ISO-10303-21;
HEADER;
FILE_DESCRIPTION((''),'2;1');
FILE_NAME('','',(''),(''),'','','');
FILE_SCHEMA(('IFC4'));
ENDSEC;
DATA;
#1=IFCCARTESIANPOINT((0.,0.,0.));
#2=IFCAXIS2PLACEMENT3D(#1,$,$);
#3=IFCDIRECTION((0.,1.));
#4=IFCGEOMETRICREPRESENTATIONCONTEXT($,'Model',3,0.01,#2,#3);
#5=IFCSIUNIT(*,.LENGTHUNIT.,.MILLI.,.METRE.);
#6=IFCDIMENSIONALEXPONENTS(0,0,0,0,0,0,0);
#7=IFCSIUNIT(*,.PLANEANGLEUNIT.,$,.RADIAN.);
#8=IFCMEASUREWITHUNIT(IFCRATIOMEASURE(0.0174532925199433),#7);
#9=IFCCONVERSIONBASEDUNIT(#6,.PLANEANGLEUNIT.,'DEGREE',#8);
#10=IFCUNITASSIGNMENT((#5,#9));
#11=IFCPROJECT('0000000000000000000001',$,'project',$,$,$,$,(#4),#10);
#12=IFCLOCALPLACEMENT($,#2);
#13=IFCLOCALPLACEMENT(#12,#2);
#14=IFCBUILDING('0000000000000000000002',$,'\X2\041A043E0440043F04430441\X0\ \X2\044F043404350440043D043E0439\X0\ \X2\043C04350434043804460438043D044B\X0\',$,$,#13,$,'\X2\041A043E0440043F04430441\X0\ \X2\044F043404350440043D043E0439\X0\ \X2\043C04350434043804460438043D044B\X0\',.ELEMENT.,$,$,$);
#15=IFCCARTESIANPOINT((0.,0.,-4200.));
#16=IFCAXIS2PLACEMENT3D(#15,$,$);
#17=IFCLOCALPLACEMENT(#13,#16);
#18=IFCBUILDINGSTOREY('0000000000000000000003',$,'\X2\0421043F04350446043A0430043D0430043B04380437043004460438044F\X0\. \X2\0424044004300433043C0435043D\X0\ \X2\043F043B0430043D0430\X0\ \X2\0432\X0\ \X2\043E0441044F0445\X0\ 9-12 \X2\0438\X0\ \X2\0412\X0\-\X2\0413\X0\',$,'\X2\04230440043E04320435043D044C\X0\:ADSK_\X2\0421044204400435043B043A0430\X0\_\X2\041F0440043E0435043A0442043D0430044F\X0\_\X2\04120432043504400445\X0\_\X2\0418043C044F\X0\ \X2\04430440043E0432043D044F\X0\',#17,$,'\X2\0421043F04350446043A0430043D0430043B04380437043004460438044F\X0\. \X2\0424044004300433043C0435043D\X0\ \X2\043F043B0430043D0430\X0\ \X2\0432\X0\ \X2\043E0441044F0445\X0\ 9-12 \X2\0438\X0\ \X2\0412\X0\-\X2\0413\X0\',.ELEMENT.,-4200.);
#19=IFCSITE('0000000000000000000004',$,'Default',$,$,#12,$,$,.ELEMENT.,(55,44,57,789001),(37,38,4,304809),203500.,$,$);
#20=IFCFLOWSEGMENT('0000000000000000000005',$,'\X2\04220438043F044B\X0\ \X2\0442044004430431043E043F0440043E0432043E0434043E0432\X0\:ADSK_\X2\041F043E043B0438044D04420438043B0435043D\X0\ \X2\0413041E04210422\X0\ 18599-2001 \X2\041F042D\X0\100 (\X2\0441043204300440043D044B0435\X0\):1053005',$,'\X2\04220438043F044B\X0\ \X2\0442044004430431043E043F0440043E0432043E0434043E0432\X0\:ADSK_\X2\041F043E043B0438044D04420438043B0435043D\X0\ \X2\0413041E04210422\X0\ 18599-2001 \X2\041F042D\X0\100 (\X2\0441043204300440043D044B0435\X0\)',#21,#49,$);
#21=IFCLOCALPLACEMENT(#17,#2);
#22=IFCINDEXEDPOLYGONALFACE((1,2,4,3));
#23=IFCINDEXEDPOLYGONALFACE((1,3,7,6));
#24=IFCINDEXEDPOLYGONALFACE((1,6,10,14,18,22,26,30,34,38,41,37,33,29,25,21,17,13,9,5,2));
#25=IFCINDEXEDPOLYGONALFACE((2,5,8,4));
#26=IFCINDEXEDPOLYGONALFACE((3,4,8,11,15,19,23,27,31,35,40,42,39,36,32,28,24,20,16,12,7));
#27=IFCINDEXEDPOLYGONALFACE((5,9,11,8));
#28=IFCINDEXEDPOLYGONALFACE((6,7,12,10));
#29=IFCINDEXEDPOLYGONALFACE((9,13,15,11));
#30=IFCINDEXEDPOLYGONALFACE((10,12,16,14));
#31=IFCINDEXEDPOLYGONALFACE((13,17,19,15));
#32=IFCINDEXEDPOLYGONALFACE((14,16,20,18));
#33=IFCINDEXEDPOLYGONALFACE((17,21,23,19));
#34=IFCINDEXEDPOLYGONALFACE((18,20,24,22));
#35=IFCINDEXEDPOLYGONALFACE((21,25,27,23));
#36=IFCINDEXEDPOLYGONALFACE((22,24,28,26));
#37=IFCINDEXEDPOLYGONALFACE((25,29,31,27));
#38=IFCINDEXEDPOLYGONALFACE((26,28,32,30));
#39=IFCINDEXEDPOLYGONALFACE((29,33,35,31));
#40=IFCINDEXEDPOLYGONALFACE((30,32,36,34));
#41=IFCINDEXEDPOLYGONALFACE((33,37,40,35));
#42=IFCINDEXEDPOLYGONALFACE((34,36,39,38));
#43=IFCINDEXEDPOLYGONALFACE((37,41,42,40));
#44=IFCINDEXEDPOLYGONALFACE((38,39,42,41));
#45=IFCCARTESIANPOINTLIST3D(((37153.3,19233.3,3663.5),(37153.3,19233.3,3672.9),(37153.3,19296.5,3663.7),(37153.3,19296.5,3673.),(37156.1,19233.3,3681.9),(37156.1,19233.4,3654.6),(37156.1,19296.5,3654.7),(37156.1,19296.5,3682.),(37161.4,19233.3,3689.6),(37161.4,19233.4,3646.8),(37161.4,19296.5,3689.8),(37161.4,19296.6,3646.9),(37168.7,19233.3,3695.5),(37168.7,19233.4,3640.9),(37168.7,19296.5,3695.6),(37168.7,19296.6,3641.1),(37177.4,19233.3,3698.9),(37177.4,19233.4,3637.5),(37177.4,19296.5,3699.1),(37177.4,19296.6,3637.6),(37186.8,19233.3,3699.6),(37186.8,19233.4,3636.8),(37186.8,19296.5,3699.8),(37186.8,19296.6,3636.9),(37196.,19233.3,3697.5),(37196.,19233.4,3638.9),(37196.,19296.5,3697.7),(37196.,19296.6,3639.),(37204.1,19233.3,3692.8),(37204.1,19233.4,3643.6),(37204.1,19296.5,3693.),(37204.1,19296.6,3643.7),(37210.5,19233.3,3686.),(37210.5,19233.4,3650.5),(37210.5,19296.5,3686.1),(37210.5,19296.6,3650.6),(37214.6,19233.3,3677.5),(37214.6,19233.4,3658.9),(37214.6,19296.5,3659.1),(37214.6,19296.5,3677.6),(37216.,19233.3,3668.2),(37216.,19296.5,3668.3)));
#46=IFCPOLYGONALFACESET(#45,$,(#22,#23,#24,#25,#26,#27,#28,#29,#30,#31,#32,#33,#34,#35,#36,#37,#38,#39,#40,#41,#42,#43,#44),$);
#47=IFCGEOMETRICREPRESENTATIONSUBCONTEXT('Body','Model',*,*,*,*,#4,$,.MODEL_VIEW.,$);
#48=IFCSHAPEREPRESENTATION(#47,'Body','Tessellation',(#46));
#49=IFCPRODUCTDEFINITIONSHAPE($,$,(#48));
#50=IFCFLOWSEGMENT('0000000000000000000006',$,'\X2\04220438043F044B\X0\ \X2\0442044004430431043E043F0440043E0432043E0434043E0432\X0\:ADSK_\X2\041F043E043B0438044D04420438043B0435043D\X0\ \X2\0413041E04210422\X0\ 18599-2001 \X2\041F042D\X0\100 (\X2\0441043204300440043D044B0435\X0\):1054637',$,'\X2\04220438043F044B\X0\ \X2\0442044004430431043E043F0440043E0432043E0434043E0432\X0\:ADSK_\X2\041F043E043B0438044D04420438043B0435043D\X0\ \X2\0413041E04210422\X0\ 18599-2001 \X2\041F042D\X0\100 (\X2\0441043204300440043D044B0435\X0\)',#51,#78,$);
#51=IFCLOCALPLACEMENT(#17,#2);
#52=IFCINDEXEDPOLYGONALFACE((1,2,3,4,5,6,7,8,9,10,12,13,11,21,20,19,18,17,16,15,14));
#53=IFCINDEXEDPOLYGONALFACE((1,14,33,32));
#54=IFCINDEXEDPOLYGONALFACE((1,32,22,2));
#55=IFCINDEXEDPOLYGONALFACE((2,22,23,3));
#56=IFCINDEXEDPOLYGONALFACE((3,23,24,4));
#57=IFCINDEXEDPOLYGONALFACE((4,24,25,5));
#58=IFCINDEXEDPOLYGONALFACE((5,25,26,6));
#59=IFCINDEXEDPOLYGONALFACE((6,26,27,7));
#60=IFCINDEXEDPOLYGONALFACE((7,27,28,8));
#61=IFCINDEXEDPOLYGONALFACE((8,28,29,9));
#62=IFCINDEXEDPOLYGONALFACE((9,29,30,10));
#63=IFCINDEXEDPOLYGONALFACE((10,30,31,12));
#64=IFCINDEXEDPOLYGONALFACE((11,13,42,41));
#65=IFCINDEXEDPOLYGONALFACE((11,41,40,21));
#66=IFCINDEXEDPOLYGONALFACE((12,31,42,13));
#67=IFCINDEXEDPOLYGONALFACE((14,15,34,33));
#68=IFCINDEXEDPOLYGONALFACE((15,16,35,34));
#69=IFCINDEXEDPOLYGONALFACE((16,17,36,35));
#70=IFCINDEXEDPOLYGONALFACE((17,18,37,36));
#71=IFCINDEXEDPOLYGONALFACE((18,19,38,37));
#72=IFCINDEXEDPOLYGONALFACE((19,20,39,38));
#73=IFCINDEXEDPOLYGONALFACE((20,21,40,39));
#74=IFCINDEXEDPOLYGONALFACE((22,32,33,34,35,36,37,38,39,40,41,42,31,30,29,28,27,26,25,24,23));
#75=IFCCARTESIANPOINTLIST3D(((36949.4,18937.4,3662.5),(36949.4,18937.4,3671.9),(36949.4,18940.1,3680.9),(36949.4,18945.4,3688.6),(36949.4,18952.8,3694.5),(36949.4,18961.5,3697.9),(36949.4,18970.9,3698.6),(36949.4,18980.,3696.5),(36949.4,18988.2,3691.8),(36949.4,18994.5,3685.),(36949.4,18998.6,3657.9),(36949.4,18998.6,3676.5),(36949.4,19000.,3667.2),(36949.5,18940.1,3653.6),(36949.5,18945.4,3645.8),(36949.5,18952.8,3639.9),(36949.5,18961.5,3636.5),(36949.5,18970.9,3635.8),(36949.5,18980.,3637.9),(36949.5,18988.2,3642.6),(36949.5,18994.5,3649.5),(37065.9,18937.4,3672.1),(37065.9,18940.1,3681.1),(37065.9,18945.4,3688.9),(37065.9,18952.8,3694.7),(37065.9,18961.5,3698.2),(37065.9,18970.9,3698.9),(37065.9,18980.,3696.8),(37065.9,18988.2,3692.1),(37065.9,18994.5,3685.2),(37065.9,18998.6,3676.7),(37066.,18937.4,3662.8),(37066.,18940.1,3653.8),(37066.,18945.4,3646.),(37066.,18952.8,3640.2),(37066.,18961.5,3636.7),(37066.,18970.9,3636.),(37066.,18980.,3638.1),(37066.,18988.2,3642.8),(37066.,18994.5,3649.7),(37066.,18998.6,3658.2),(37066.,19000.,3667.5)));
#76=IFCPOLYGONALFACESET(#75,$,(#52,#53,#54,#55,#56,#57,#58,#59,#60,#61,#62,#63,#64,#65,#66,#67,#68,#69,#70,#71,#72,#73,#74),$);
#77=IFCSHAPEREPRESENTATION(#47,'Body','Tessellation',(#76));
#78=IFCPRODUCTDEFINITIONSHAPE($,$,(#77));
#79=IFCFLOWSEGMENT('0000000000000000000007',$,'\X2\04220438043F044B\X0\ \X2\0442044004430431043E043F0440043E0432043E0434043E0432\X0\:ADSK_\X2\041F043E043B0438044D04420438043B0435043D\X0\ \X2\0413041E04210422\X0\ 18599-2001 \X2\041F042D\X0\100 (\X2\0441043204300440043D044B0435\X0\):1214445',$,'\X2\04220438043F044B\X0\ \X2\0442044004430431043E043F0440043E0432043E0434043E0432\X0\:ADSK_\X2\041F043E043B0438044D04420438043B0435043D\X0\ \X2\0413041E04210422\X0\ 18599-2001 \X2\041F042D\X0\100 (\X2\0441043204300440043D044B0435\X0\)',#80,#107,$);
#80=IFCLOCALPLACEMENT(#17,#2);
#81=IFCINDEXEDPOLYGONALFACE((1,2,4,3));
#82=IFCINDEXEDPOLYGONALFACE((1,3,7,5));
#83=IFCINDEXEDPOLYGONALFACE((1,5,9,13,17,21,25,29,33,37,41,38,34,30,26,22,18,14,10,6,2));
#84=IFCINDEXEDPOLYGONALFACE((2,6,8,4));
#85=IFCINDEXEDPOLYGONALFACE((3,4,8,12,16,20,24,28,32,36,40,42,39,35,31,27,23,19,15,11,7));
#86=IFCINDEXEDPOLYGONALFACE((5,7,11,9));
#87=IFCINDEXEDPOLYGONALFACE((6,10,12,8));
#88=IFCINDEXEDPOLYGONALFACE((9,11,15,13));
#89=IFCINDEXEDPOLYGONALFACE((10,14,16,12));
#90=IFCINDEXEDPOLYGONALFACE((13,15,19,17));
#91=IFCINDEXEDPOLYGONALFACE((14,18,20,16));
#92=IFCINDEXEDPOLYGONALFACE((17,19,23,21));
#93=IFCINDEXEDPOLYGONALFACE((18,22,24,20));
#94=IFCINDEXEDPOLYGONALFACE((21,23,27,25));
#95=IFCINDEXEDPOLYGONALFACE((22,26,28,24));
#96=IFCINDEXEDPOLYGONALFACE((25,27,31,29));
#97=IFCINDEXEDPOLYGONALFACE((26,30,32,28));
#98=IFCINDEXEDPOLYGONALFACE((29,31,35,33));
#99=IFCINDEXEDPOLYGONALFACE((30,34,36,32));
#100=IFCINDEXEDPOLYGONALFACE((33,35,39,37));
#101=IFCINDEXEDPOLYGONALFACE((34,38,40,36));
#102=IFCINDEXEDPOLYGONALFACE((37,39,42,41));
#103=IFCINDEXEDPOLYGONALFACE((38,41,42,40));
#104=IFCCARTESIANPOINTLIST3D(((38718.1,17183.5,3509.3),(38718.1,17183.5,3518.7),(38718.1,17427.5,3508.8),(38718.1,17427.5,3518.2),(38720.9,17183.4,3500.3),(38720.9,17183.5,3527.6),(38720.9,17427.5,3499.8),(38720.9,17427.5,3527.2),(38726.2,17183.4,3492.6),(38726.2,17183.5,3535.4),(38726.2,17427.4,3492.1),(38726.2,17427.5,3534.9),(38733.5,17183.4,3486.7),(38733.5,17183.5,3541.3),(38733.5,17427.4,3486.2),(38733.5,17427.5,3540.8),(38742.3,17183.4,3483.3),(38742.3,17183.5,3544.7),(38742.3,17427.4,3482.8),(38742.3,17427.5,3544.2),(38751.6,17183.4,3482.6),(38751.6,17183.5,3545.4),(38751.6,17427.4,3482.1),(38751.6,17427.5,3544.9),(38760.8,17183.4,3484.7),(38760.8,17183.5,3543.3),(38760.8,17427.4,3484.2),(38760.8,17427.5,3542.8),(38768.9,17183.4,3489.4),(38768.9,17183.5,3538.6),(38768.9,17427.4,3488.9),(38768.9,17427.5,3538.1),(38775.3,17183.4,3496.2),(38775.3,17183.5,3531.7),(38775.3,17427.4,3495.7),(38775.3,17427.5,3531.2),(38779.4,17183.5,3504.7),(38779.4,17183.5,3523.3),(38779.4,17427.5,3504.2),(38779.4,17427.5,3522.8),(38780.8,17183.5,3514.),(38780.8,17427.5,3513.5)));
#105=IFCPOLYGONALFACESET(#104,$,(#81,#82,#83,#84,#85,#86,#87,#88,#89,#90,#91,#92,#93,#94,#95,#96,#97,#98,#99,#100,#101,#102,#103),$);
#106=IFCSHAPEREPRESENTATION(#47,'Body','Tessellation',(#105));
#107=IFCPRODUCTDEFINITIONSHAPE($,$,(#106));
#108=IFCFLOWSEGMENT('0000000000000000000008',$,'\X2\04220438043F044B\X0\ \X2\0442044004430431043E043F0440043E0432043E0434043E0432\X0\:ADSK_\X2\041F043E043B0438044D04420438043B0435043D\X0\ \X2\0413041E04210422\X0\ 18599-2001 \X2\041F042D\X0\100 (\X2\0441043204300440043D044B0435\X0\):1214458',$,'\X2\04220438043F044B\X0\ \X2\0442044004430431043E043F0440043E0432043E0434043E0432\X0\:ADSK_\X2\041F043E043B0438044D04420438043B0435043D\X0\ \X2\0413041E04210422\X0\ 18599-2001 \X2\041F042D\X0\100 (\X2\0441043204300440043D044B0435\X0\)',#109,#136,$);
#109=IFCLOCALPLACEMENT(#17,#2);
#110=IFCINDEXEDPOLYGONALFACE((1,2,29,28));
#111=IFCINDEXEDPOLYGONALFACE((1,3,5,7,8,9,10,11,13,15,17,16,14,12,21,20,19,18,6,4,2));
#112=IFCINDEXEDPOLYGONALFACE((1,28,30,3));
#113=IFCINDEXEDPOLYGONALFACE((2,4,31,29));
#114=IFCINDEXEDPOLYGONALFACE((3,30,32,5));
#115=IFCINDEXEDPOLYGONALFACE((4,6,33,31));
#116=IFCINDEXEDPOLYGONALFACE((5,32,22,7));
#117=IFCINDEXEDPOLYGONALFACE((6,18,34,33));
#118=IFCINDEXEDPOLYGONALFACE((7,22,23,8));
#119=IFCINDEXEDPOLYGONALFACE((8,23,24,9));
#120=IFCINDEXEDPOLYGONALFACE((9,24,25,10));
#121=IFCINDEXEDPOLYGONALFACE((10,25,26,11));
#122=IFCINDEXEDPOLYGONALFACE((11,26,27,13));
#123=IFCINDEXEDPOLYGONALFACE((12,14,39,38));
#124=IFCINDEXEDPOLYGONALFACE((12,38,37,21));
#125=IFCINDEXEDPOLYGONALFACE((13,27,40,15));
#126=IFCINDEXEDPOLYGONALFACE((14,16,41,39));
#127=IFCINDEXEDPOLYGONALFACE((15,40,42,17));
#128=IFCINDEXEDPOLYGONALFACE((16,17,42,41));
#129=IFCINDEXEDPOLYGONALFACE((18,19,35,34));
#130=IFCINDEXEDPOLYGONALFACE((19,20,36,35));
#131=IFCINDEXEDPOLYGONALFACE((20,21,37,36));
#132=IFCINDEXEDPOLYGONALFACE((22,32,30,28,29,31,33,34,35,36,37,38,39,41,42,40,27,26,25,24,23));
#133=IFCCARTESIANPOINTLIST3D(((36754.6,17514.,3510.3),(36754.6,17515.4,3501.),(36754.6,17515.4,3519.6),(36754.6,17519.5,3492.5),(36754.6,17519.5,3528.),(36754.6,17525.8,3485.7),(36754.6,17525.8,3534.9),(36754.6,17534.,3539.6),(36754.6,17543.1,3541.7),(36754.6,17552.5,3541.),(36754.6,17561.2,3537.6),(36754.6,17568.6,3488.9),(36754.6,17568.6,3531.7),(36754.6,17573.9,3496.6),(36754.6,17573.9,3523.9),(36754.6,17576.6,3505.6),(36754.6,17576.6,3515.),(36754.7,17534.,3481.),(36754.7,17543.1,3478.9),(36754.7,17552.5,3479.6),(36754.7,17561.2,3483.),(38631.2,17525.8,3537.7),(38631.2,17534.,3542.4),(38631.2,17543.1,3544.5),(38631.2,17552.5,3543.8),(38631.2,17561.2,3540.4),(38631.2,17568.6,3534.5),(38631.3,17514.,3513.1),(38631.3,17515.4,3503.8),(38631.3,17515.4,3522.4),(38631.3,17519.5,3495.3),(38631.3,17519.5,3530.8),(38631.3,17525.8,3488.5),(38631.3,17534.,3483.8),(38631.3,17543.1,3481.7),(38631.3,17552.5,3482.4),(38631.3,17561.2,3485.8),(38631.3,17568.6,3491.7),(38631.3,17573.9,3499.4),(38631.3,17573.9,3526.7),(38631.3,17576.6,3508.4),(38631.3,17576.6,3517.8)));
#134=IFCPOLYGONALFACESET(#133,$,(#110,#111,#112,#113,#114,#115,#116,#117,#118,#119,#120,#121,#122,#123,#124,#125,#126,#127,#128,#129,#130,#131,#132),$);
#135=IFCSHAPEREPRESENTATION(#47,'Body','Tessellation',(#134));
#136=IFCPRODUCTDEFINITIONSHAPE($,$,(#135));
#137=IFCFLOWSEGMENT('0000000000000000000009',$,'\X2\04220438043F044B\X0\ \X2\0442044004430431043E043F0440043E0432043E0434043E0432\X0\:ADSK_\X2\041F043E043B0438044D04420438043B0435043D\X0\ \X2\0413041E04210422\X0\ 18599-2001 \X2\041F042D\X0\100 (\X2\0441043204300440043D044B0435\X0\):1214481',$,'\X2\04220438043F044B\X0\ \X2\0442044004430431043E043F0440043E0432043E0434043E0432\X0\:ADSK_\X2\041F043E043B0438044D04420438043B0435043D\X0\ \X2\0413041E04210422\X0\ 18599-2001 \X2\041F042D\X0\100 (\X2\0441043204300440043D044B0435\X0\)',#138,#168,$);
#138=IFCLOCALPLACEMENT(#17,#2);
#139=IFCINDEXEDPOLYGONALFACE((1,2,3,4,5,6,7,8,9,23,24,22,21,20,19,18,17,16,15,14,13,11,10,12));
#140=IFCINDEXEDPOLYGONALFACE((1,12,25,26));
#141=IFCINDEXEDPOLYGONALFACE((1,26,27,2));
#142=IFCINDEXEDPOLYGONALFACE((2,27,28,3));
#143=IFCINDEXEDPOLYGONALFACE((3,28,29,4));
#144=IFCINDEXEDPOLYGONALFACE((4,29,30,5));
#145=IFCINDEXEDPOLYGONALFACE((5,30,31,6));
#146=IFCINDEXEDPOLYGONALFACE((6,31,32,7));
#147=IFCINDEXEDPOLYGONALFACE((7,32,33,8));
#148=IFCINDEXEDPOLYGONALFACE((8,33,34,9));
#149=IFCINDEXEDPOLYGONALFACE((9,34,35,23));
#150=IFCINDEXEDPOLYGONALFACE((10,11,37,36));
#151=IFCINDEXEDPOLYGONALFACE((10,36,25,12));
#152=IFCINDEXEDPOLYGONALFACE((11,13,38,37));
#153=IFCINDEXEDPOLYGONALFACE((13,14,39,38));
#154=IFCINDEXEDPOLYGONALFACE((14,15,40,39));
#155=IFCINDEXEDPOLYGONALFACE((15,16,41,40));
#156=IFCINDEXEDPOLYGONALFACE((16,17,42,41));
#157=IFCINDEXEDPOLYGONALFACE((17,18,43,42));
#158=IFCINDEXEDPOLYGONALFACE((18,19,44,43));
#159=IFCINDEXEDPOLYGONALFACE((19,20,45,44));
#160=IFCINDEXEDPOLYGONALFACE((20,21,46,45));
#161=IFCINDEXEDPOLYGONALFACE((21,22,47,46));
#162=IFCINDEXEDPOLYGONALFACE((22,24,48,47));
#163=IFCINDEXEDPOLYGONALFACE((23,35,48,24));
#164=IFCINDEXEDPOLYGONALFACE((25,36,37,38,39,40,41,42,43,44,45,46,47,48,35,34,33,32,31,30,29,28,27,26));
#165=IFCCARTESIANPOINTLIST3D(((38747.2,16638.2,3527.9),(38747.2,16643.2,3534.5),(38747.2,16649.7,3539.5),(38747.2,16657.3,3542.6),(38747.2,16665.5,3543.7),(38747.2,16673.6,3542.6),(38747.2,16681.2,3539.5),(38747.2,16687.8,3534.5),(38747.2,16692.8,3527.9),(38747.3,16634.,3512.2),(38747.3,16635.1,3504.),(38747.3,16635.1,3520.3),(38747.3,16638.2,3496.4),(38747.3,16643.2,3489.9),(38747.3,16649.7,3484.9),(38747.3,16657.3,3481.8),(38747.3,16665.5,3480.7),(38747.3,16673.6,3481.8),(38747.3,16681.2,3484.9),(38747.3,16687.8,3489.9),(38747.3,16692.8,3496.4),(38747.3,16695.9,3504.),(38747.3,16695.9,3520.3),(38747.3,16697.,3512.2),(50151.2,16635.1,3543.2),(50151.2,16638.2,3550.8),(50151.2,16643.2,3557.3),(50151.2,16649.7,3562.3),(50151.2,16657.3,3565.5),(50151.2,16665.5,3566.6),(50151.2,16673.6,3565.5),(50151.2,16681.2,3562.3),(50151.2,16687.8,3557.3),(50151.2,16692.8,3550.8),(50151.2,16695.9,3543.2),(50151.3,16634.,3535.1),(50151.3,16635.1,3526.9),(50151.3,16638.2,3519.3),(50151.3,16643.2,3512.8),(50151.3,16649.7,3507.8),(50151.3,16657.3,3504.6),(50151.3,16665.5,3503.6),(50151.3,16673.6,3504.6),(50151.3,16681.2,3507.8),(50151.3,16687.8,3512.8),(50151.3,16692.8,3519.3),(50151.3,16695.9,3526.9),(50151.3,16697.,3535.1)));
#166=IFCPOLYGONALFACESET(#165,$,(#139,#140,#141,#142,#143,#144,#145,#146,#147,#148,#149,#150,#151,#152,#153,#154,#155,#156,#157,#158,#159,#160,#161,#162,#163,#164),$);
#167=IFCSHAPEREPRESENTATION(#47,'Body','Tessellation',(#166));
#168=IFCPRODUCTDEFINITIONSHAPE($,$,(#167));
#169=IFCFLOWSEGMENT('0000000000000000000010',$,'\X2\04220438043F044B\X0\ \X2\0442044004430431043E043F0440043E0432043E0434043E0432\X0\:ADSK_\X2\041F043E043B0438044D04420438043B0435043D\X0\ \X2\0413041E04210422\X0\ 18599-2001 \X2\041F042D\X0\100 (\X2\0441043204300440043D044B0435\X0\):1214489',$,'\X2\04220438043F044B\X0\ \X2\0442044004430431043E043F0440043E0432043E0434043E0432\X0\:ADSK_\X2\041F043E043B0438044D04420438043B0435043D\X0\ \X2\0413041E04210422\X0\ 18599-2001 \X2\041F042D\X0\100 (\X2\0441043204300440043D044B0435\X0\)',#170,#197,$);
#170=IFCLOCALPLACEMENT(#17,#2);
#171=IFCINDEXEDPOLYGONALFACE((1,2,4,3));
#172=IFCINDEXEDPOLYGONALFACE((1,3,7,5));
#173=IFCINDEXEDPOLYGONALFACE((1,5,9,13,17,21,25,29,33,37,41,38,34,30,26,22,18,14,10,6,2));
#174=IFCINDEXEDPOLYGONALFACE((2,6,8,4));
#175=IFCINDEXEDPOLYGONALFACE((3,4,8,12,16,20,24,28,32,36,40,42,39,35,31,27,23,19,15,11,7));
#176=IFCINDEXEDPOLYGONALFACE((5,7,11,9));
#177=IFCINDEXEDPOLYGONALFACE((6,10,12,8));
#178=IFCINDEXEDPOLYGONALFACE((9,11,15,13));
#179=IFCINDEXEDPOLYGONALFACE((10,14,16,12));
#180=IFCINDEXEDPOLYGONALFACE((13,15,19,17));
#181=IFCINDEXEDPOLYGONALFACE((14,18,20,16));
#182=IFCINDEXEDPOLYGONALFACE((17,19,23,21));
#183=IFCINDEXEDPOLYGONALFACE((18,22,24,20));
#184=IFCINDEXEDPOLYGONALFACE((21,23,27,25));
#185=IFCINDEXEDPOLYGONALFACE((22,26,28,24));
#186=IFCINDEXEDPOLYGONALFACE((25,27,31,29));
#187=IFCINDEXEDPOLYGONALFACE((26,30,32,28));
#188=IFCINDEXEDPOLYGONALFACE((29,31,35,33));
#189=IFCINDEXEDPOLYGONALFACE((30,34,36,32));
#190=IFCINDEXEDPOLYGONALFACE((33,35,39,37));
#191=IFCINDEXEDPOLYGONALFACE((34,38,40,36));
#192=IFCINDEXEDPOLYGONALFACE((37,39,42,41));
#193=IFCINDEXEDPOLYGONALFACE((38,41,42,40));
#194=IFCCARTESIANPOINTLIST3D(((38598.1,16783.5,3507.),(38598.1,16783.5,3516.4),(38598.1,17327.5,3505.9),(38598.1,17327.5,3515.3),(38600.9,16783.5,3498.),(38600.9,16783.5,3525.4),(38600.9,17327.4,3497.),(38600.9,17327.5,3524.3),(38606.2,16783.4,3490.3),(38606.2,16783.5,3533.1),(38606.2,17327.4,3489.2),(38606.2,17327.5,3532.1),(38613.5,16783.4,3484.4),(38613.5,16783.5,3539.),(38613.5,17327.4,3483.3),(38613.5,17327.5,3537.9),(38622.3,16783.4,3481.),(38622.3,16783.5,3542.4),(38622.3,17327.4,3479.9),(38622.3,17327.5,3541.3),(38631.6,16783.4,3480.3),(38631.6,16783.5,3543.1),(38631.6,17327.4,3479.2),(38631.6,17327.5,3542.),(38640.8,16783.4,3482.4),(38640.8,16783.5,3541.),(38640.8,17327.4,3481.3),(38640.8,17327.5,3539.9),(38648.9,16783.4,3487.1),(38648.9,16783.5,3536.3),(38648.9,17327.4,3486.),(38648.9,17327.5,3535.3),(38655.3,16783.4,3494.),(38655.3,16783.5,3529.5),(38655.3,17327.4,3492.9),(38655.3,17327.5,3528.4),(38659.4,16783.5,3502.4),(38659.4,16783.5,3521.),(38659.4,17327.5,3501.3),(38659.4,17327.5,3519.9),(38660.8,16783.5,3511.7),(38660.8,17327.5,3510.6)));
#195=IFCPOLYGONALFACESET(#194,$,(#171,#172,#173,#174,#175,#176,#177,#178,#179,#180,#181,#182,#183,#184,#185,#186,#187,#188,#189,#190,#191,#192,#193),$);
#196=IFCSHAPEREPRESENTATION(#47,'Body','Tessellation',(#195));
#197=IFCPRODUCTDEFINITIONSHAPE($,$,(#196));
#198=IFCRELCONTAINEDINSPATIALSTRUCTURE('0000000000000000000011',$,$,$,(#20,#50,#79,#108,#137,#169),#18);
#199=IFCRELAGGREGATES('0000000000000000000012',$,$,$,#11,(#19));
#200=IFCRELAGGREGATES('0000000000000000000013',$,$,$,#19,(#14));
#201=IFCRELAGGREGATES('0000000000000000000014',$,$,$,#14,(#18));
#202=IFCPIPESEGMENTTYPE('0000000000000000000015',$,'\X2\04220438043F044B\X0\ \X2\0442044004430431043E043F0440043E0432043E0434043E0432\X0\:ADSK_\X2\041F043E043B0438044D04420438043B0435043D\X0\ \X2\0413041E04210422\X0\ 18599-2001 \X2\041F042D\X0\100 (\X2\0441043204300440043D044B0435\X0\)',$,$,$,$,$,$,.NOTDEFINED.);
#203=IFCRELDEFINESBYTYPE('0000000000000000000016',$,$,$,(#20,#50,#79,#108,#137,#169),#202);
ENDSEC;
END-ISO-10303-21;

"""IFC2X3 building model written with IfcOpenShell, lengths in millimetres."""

from ifc_helpers import new_model, entity, si_unit, converted_unit, direction, frame, frame_2d, origin, origin_2d_with_axis, place, context, subcontext, project, spatial, polyline, circle, outline, extrude, type_object, element, save


model = new_model("IFC2X3")

# Units and contexts
model_context = context("Model", 3, precision=0.01, world=origin(), true_north=direction((0.0, 1.0)))
body_context = subcontext(model_context, "Body", "Model", "MODEL_VIEW")
ifc_project = project(units=[si_unit("LENGTHUNIT", "METRE", prefix="MILLI"), converted_unit("PLANEANGLEUNIT", "DEGREE", entity("IfcRatioMeasure", 0.0174532925199433), si_unit("PLANEANGLEUNIT", "RADIAN"), dimensions=[0, 0, 0, 0, 0, 0, 0])], contexts=[model_context])

# Site, building, storey
site_placement = place(None, frame((0.0, 0.0, 0.0)))
site = spatial("IfcSite", under=ifc_project, at=site_placement, Name="Default", CompositionType="ELEMENT", RefLatitude=(55, 44, 57, 789001), RefLongitude=(37, 38, 4, 304809), RefElevation=203500.0)
building_placement = place(site_placement, origin())
building = spatial("IfcBuilding", under=site, at=building_placement, Name="Корпус ядерной медицины", LongName="Корпус ядерной медицины", CompositionType="ELEMENT")
storey_placement = place(building_placement, frame((0.0, 0.0, -4200.0)))
storey = spatial("IfcBuildingStorey", under=building, at=storey_placement, Name="Спецканализация. Фрагмен плана в осях 9-12 и В-Г", ObjectType="Уровень:ADSK_Стрелка_Проектная_Вверх_Имя уровня", LongName="Спецканализация. Фрагмен плана в осях 9-12 и В-Г", CompositionType="ELEMENT", Elevation=-4200.0)

# Flow segments
pipe_segment_type = type_object("IfcPipeSegmentType", Name="Типы трубопроводов:ADSK_Полиэтилен ГОСТ 18599-2001 ПЭ100 (сварные)", PredefinedType="NOTDEFINED")
flow_segment_1_placement = place(storey_placement, frame((37151.4, 19233.3, 3635.1)))
element("IfcFlowSegment", 1, at=flow_segment_1_placement, inside=storey, type_object=pipe_segment_type, Name="Типы трубопроводов:ADSK_Полиэтилен ГОСТ 18599-2001 ПЭ100 (сварные):1053005", ObjectType="Типы трубопроводов:ADSK_Полиэтилен ГОСТ 18599-2001 ПЭ100 (сварные)", context=body_context, shape_type="SweptSolid", body=[
    extrude(circle(Radius=31.5, at=frame_2d((0.0, 0.0), x_axis=(1.0, 0.0))), frame((33.1, 0.1, 33.1), z_axis=(0.0, 0.999998, 0.002007), x_axis=(1.0, 0.0, 0.0)), (0.0, 0.0, 1.0), 63.2),
])
flow_segment_2_placement = place(storey_placement, frame((36949.4, 18935.4, 3634.1)))
element("IfcFlowSegment", 2, at=flow_segment_2_placement, inside=storey, type_object=pipe_segment_type, Name="Типы трубопроводов:ADSK_Полиэтилен ГОСТ 18599-2001 ПЭ100 (сварные):1054637", ObjectType="Типы трубопроводов:ADSK_Полиэтилен ГОСТ 18599-2001 ПЭ100 (сварные)", context=body_context, shape_type="SweptSolid", body=[
    extrude(circle(Radius=31.5, at=frame_2d((0.0, 0.0), x_axis=(1.0, 0.0))), frame((0.1, 33.1, 33.1), z_axis=(0.999998, 0.0, 0.002), x_axis=(0.0, 1.0, 0.0)), (0.0, 0.0, 1.0), 116.5),
])
flow_segment_3_placement = place(storey_placement, frame((38716.2, 17183.4, 3480.4)))
element("IfcFlowSegment", 3, at=flow_segment_3_placement, inside=storey, type_object=pipe_segment_type, Name="Типы трубопроводов:ADSK_Полиэтилен ГОСТ 18599-2001 ПЭ100 (сварные):1214445", ObjectType="Типы трубопроводов:ADSK_Полиэтилен ГОСТ 18599-2001 ПЭ100 (сварные)", context=body_context, shape_type="SweptSolid", body=[
    extrude(circle(Radius=31.5, at=origin_2d_with_axis()), frame((33.1, 244.1, 33.1), z_axis=(0.0, -0.999998, 0.002), x_axis=(1.0, 0.0, 0.0)), (0.0, 0.0, 1.0), 244.0),
])
flow_segment_4_placement = place(storey_placement, frame((36754.6, 17512.4, 3477.2)))
element("IfcFlowSegment", 4, at=flow_segment_4_placement, inside=storey, type_object=pipe_segment_type, Name="Типы трубопроводов:ADSK_Полиэтилен ГОСТ 18599-2001 ПЭ100 (сварные):1214458", ObjectType="Типы трубопроводов:ADSK_Полиэтилен ГОСТ 18599-2001 ПЭ100 (сварные)", context=body_context, shape_type="SweptSolid", body=[
    extrude(circle(Radius=31.5, at=origin_2d_with_axis()), frame((0.0, 33.1, 33.1), z_axis=(0.999999, 0.0, 0.001491), x_axis=(0.0, -1.0, 0.0)), (0.0, 0.0, 1.0), 1876.7),
])
flow_segment_5_placement = place(storey_placement, frame((38747.2, 16632.4, 3479.1)))
element("IfcFlowSegment", 5, at=flow_segment_5_placement, inside=storey, type_object=pipe_segment_type, Name="Типы трубопроводов:ADSK_Полиэтилен ГОСТ 18599-2001 ПЭ100 (сварные):1214481", ObjectType="Типы трубопроводов:ADSK_Полиэтилен ГОСТ 18599-2001 ПЭ100 (сварные)", context=body_context, shape_type="SweptSolid", body=[
    extrude(outline(polyline([(-4.1, -31.2), (4.1, -31.2), (12.1, -29.1), (19.2, -25.0), (25.0, -19.2), (29.1, -12.1), (31.2, -4.1), (31.2, 4.1), (29.1, 12.1), (25.0, 19.2), (19.2, 25.0), (12.1, 29.1), (4.1, 31.2), (-4.1, 31.2), (-12.1, 29.1), (-19.2, 25.0), (-25.0, 19.2), (-29.1, 12.1), (-31.2, 4.1), (-31.2, -4.1), (-29.1, -12.1), (-25.0, -19.2), (-19.2, -25.0), (-12.1, -29.1), (-4.1, -31.2)])), frame((0.1, 33.1, 33.1), z_axis=(0.999998, 0.0, 0.002005), x_axis=(-0.001988, -0.130526, 0.991443)), (0.0, 0.0, 1.0), 11404.0),
])
flow_segment_6_placement = place(storey_placement, frame((38596.2, 16783.4, 3477.5)))
element("IfcFlowSegment", 6, at=flow_segment_6_placement, inside=storey, type_object=pipe_segment_type, Name="Типы трубопроводов:ADSK_Полиэтилен ГОСТ 18599-2001 ПЭ100 (сварные):1214489", ObjectType="Типы трубопроводов:ADSK_Полиэтилен ГОСТ 18599-2001 ПЭ100 (сварные)", context=body_context, shape_type="SweptSolid", body=[
    extrude(circle(Radius=31.5, at=origin_2d_with_axis()), frame((33.1, 544.1, 33.1), z_axis=(0.0, -0.999998, 0.002), x_axis=(1.0, 0.0, 0.0)), (0.0, 0.0, 1.0), 544.0),
])

save(model, "model.ifc")
